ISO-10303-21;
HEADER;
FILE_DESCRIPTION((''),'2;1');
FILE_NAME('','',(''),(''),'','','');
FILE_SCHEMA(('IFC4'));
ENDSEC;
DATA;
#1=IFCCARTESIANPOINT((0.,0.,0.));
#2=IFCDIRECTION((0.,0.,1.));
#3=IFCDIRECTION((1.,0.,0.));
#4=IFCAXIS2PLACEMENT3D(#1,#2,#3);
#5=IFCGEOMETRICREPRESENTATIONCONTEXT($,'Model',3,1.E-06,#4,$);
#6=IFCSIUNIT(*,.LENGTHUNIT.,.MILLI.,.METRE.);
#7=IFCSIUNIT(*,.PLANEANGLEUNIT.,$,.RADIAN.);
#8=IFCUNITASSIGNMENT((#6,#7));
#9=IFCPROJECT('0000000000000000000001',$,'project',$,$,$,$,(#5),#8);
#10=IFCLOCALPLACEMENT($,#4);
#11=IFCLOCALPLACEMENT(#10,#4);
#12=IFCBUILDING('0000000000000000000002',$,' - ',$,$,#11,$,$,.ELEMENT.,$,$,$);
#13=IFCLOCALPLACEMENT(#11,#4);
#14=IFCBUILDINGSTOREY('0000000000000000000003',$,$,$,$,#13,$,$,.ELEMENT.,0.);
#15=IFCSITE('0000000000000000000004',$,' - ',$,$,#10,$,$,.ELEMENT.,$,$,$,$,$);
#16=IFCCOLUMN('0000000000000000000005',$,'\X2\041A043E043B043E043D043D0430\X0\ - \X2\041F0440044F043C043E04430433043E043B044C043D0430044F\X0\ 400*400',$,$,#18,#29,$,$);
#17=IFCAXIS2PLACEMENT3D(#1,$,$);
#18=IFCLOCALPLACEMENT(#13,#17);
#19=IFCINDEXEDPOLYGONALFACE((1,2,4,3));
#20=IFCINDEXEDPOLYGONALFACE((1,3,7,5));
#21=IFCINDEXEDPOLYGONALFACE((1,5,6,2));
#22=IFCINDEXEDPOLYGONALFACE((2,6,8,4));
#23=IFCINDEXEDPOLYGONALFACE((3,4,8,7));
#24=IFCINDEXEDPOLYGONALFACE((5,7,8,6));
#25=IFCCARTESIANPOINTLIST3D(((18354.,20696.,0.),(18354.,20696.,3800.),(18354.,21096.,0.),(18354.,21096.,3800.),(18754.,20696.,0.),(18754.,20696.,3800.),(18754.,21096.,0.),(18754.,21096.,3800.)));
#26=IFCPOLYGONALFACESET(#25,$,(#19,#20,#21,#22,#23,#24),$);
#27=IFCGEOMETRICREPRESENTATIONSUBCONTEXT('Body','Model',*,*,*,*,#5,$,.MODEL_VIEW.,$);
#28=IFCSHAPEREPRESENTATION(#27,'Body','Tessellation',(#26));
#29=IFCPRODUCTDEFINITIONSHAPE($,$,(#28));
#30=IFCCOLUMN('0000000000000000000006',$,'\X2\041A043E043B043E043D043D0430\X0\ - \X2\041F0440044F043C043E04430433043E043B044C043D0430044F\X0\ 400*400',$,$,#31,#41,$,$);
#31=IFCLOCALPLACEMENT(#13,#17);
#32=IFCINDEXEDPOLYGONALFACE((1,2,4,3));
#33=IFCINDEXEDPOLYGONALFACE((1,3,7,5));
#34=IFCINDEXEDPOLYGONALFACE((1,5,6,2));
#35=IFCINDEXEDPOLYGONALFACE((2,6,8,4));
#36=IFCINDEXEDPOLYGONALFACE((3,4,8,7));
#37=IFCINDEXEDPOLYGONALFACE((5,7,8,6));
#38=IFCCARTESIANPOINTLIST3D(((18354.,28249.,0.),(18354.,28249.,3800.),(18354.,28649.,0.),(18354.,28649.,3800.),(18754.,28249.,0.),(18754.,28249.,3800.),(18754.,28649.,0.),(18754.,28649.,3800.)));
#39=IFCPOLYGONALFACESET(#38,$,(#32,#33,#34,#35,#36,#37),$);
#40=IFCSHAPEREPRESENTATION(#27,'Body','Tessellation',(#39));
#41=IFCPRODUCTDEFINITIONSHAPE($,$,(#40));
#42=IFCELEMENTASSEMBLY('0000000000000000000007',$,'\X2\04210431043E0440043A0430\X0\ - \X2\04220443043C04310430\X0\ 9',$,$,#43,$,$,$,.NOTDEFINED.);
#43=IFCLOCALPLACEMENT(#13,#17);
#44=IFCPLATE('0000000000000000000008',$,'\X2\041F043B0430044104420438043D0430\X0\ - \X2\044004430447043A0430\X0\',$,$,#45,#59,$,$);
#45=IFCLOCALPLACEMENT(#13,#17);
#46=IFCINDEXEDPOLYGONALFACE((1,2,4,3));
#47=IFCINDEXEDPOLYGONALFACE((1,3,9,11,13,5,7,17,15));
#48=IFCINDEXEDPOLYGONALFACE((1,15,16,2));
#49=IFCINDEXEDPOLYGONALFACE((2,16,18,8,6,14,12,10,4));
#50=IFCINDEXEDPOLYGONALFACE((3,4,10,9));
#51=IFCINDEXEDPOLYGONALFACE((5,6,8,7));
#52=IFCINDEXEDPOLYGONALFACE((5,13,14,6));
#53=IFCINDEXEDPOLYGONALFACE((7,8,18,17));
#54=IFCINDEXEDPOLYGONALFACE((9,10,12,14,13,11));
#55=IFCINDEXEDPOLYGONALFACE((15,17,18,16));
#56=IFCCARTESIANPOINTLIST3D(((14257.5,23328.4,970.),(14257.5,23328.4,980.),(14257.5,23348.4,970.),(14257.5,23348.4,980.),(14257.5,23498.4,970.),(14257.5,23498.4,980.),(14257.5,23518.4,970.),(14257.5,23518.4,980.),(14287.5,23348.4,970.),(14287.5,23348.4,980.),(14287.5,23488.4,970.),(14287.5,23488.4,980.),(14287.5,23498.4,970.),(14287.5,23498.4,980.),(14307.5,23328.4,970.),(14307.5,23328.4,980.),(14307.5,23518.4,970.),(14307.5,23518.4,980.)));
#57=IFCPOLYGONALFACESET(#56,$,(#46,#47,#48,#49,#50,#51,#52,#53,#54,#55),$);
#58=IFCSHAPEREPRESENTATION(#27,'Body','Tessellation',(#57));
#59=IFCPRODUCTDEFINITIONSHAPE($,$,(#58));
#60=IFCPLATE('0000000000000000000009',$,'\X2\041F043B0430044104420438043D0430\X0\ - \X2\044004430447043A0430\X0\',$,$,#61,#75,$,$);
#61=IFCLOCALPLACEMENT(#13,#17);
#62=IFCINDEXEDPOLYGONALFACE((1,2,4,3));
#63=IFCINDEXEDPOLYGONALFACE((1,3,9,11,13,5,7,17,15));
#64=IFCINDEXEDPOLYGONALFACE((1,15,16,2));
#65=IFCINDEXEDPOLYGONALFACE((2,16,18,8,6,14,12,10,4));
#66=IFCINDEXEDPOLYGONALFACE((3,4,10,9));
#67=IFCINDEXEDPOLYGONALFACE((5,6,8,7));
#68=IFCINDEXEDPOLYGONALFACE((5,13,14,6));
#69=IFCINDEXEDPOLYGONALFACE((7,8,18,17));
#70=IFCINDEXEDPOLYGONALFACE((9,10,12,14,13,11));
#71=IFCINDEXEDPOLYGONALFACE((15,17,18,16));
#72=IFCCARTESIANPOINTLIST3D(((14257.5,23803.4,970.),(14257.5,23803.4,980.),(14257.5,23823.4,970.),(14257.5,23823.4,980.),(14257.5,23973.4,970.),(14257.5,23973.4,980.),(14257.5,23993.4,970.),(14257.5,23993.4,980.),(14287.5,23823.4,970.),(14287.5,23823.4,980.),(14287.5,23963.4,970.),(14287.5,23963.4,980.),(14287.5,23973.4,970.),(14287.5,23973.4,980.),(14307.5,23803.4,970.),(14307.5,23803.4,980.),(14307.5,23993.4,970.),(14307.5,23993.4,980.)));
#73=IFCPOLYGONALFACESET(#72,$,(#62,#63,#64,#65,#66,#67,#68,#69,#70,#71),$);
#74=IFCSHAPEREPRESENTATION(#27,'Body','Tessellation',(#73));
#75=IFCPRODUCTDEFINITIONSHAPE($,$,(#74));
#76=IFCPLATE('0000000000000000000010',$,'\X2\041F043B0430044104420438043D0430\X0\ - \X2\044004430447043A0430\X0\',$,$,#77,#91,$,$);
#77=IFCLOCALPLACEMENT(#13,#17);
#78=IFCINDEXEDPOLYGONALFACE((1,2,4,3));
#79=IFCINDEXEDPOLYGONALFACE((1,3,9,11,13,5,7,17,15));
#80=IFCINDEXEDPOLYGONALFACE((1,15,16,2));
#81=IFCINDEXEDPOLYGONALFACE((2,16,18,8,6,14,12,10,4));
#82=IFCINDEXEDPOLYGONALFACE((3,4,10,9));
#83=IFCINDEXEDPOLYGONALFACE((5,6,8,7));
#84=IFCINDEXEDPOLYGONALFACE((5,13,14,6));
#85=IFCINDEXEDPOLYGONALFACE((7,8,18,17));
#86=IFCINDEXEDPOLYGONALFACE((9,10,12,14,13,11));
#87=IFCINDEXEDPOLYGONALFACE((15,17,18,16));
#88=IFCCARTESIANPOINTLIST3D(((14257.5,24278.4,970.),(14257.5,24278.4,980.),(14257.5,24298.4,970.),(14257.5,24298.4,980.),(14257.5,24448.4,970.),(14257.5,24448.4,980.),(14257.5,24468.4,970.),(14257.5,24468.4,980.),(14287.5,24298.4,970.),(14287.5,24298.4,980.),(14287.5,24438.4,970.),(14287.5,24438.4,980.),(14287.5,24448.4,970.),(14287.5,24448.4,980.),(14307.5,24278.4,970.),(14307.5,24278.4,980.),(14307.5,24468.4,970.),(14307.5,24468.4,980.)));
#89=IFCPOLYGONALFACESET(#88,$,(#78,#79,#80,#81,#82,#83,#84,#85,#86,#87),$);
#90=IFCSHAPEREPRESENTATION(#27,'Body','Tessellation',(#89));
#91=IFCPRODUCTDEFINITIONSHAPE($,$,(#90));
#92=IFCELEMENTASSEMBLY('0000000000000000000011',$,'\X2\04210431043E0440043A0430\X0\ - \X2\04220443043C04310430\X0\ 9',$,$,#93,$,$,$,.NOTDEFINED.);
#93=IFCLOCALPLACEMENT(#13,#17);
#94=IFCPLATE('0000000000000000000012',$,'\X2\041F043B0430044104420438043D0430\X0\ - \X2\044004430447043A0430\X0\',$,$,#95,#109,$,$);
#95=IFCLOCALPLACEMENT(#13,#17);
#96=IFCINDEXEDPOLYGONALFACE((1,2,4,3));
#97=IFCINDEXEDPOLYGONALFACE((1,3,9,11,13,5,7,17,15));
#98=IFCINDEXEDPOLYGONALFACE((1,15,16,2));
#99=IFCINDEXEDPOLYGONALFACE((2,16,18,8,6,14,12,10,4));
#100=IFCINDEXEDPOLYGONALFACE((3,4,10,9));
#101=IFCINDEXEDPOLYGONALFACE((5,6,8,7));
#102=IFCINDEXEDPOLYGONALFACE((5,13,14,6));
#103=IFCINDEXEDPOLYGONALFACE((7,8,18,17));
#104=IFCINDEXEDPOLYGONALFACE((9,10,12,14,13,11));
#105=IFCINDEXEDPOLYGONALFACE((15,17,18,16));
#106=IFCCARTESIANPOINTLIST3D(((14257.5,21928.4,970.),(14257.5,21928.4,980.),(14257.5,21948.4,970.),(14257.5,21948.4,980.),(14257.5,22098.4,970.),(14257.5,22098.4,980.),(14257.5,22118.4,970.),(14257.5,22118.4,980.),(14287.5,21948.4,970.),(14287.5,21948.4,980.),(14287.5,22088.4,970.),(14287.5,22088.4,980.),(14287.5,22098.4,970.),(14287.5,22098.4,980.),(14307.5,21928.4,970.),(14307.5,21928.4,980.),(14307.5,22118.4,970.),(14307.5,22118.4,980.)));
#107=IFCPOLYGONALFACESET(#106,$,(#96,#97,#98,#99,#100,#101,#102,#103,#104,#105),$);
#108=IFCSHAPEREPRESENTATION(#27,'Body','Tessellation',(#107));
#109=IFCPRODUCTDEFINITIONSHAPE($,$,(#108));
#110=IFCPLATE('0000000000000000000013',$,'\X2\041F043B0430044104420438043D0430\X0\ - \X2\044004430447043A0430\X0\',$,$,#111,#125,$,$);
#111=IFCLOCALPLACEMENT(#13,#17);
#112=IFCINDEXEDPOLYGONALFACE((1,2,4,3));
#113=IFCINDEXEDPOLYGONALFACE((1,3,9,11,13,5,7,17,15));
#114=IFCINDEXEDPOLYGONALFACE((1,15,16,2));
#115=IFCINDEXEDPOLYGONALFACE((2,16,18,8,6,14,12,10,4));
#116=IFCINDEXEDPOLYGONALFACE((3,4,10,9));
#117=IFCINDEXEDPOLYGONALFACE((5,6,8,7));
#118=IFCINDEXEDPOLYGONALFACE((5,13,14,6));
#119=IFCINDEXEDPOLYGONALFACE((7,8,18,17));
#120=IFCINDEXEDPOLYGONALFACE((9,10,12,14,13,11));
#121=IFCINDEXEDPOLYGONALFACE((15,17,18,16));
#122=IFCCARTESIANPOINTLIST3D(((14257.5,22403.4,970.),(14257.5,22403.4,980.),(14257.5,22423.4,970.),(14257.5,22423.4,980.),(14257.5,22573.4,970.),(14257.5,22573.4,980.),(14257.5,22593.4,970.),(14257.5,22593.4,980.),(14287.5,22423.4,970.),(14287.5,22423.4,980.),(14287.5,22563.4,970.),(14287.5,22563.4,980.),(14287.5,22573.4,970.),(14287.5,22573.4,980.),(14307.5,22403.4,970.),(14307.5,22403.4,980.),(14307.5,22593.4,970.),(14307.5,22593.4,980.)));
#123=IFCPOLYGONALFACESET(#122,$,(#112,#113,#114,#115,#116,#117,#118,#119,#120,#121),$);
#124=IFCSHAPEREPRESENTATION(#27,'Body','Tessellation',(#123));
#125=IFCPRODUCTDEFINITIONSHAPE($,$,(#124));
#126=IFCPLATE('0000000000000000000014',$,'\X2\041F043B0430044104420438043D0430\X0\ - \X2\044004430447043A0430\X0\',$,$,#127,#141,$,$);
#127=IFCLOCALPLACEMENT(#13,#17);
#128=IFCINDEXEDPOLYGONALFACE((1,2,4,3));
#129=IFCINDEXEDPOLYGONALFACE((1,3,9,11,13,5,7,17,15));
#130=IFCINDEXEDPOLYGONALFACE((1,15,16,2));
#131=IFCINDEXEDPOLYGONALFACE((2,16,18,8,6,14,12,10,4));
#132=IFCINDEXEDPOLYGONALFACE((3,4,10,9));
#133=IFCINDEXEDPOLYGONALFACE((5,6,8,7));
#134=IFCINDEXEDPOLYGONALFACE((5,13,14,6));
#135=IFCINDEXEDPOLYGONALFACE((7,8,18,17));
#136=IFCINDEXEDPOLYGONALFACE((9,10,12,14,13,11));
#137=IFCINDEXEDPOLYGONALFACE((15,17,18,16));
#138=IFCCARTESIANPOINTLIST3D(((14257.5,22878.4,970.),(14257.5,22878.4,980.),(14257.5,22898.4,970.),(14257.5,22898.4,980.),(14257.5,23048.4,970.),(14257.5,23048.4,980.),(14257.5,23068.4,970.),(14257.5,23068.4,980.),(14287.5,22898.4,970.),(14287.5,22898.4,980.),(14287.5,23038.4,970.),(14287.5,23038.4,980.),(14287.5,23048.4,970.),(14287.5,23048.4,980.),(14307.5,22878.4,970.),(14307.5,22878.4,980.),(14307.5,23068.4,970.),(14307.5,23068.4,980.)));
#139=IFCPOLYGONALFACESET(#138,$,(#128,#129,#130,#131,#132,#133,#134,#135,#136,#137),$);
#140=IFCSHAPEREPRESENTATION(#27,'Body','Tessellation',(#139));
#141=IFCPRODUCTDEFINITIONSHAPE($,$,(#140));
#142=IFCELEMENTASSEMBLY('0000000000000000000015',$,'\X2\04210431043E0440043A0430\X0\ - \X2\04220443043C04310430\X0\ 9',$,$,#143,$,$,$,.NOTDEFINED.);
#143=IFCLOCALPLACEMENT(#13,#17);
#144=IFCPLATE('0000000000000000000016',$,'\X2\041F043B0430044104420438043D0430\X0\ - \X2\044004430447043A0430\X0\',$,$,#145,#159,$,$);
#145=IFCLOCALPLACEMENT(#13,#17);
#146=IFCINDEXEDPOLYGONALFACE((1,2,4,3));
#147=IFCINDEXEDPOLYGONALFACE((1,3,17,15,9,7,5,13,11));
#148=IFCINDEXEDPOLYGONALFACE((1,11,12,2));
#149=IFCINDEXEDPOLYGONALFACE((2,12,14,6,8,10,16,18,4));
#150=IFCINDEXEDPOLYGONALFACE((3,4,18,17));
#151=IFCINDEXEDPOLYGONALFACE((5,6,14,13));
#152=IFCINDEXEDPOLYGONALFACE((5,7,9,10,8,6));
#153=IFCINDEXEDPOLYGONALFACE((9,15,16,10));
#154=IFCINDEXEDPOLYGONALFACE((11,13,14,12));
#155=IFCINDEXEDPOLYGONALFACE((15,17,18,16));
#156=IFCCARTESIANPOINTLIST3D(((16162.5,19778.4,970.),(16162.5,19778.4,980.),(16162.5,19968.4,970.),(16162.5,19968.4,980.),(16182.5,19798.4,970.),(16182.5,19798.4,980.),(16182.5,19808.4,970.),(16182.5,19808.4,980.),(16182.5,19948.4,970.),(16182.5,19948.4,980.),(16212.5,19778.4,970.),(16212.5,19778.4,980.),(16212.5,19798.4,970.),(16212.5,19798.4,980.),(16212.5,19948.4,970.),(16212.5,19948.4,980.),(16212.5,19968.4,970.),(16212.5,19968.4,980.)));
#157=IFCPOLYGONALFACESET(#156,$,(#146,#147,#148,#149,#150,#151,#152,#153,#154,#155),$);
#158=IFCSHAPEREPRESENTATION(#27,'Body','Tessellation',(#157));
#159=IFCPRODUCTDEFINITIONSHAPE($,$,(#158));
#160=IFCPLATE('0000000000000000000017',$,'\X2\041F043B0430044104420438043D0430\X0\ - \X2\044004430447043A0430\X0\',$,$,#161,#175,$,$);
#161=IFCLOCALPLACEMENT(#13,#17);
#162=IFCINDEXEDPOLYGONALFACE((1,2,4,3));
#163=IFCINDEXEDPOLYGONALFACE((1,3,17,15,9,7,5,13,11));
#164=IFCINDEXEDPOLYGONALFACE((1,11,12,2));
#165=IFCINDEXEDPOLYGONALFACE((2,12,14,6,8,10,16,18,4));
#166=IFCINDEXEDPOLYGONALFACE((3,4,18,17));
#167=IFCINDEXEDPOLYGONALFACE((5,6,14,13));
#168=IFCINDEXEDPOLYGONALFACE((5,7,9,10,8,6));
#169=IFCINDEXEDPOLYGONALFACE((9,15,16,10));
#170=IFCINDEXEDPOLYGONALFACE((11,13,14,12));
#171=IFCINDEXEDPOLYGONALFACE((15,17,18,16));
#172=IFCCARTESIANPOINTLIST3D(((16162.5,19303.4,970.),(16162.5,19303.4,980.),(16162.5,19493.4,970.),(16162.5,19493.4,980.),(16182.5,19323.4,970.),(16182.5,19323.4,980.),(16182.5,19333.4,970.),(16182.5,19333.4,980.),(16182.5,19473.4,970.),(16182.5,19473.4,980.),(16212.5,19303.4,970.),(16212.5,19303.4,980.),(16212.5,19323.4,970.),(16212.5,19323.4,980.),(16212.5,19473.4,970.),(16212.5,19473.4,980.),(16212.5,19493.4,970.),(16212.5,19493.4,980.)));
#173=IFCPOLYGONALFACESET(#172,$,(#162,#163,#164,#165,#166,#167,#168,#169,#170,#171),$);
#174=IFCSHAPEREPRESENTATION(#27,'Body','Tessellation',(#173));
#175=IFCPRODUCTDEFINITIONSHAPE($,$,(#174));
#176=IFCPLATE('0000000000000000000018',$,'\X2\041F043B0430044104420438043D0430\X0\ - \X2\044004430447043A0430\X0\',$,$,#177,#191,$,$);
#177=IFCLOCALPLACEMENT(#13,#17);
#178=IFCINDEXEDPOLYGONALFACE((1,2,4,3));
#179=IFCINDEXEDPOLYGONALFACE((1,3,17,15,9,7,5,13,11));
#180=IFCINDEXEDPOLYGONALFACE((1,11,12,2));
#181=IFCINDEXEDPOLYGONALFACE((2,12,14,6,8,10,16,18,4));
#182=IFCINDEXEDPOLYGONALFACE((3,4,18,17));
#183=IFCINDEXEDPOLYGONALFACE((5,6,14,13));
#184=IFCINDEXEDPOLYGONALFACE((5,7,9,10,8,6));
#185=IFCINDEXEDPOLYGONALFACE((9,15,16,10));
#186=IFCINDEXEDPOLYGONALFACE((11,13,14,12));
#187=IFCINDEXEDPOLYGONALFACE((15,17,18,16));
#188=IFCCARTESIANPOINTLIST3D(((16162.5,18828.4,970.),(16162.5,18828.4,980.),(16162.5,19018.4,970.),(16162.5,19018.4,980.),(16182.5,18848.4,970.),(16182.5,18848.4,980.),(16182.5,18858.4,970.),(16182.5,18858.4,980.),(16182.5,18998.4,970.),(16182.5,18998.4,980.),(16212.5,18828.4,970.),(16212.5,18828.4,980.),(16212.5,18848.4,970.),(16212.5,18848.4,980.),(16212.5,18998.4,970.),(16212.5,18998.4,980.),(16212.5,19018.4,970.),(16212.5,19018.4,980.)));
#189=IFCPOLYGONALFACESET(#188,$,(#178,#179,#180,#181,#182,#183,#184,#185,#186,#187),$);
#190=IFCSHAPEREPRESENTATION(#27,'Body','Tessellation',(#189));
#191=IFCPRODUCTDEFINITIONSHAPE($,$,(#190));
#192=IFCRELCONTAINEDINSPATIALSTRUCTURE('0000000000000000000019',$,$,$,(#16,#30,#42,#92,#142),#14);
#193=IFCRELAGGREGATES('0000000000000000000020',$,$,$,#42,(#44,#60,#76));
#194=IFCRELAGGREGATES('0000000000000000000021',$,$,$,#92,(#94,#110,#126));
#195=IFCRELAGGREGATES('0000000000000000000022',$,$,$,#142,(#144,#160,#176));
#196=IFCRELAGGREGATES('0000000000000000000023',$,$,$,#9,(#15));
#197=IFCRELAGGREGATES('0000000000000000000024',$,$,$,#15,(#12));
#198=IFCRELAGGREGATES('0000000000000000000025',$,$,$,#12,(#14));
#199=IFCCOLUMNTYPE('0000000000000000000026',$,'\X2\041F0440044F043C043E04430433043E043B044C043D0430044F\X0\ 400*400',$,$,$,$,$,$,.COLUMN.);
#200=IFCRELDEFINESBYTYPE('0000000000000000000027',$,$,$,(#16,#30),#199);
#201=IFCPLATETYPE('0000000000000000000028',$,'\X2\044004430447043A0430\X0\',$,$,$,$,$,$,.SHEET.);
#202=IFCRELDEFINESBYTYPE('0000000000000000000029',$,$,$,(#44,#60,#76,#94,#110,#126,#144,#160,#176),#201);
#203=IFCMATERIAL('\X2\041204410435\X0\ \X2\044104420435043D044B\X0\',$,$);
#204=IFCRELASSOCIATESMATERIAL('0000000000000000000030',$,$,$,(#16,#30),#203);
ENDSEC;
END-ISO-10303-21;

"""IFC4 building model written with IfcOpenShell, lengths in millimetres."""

from ifc_helpers import new_model, si_unit, frame, origin_with_axes, place, context, subcontext, project, spatial, line, indexed_curve, outline, extrude, source, transform, mapped, material, type_object, element, aggregate, save


model = new_model("IFC4")

# Units and contexts
model_context = context("Model", 3, precision=1e-06, world=origin_with_axes())
body_context = subcontext(model_context, "Body", "Model", "MODEL_VIEW")
ifc_project = project(units=[si_unit("LENGTHUNIT", "METRE", prefix="MILLI"), si_unit("PLANEANGLEUNIT", "RADIAN")], contexts=[model_context])

# Site, building, storey
site_placement = place(None, origin_with_axes())
site = spatial("IfcSite", under=ifc_project, at=site_placement, Name=" - ", CompositionType="ELEMENT")
building_placement = place(site_placement, origin_with_axes())
building = spatial("IfcBuilding", under=site, at=building_placement, Name=" - ", CompositionType="ELEMENT")
storey_placement = place(building_placement, origin_with_axes())
storey = spatial("IfcBuildingStorey", under=building, at=storey_placement, CompositionType="ELEMENT", Elevation=0.0)

# Columns
ifc_material = material(Name="Все стены")
column_type = type_object("IfcColumnType", Name="Прямоугольная 400*400", PredefinedType="COLUMN")
shared_shape_1 = source(origin_with_axes(), body_context, "Body", "SweptSolid", [
    extrude(outline(indexed_curve([(-200.0, -200.0), (200.0, -200.0), (200.0, 200.0), (-200.0, 200.0)], segments=[line(1, 2), line(2, 3), line(3, 4), line(4, 1)])), origin_with_axes(), (0.0, 0.0, 1.0), 3800.0),
])
for number, where, z_axis, x_axis, name in (
    (1, (18554.0, 20896.0, 0.0), (0.0, 0.0, 1.0), (1.0, 0.0, 0.0), "Колонна - Прямоугольная 400*400"),
    (2, (18554.0, 28449.0, 0.0), (0.0, 0.0, 1.0), (1.0, 0.0, 0.0), "Колонна - Прямоугольная 400*400"),
):
    element("IfcColumn", number, at=place(storey_placement, frame(where, z_axis=z_axis, x_axis=x_axis)), inside=storey, type_object=column_type, material=ifc_material, Name=name, context=body_context, shape_type="MappedRepresentation", body=[
        mapped(shared_shape_1, transform((0.0, 0.0, 0.0), x_axis=(1.0, 0.0, 0.0), y_axis=(0.0, 1.0, 0.0), z_axis=(0.0, 0.0, 1.0), scale=1.0)),
    ])

# Element assemblies, plates
assembly_1_placement = place(storey_placement, frame((14042.5, 23898.4, 0.0), z_axis=(0.0, 0.0, 1.0), x_axis=(0.0, 1.0, 0.0)))
assembly_1 = element("IfcElementAssembly", 3, at=assembly_1_placement, inside=storey, Name="Сборка - Тумба 9", PredefinedType="NOTDEFINED")
plate_type = type_object("IfcPlateType", Name="ручка", PredefinedType="SHEET")
shared_shape_2 = source(origin_with_axes(), body_context, "Body", "SweptSolid", [
    extrude(outline(indexed_curve([(-95.0, -25.0), (-75.0, -25.0), (-75.0, 5.0), (-65.0, 5.0), (75.0, 5.0), (75.0, -25.0), (95.0, -25.0), (95.0, 25.0), (-95.0, 25.0)], segments=[line(1, 2), line(2, 3), line(3, 4), line(4, 5), line(5, 6), line(6, 7), line(7, 8), line(8, 9), line(9, 1)])), origin_with_axes(), (0.0, 0.0, 1.0), 10.0),
])
plate_1_placement = place(assembly_1_placement, frame((-475.0, -240.0, 970.0), z_axis=(0.0, 0.0, 1.0), x_axis=(-1.0, 0.0, 0.0)))
plate_1 = element("IfcPlate", 4, at=plate_1_placement, type_object=plate_type, Name="Пластина - ручка", context=body_context, shape_type="MappedRepresentation", body=[
    mapped(shared_shape_2, transform((0.0, 0.0, 0.0), x_axis=(1.0, 0.0, 0.0), y_axis=(0.0, 1.0, 0.0), z_axis=(0.0, 0.0, 1.0), scale=1.0)),
])
plate_2_placement = place(assembly_1_placement, frame((0.0, -240.0, 970.0), z_axis=(0.0, 0.0, 1.0), x_axis=(-1.0, 0.0, 0.0)))
plate_2 = element("IfcPlate", 5, at=plate_2_placement, type_object=plate_type, Name="Пластина - ручка", context=body_context, shape_type="MappedRepresentation", body=[
    mapped(shared_shape_2, transform((0.0, 0.0, 0.0), x_axis=(1.0, 0.0, 0.0), y_axis=(0.0, 1.0, 0.0), z_axis=(0.0, 0.0, 1.0), scale=1.0)),
])
plate_3_placement = place(assembly_1_placement, frame((475.0, -240.0, 970.0), z_axis=(0.0, 0.0, 1.0), x_axis=(-1.0, 0.0, 0.0)))
plate_3 = element("IfcPlate", 6, at=plate_3_placement, type_object=plate_type, Name="Пластина - ручка", context=body_context, shape_type="MappedRepresentation", body=[
    mapped(shared_shape_2, transform((0.0, 0.0, 0.0), x_axis=(1.0, 0.0, 0.0), y_axis=(0.0, 1.0, 0.0), z_axis=(0.0, 0.0, 1.0), scale=1.0)),
])
aggregate(assembly_1, [plate_1, plate_2, plate_3])
assembly_2_placement = place(storey_placement, frame((14042.5, 22498.4, 0.0), z_axis=(0.0, 0.0, 1.0), x_axis=(0.0, 1.0, 0.0)))
assembly_2 = element("IfcElementAssembly", 7, at=assembly_2_placement, inside=storey, Name="Сборка - Тумба 9", PredefinedType="NOTDEFINED")
plate_4_placement = place(assembly_2_placement, frame((-475.0, -240.0, 970.0), z_axis=(0.0, 0.0, 1.0), x_axis=(-1.0, 0.0, 0.0)))
plate_4 = element("IfcPlate", 8, at=plate_4_placement, type_object=plate_type, Name="Пластина - ручка", context=body_context, shape_type="MappedRepresentation", body=[
    mapped(shared_shape_2, transform((0.0, 0.0, 0.0), x_axis=(1.0, 0.0, 0.0), y_axis=(0.0, 1.0, 0.0), z_axis=(0.0, 0.0, 1.0), scale=1.0)),
])
plate_5_placement = place(assembly_2_placement, frame((0.0, -240.0, 970.0), z_axis=(0.0, 0.0, 1.0), x_axis=(-1.0, 0.0, 0.0)))
plate_5 = element("IfcPlate", 9, at=plate_5_placement, type_object=plate_type, Name="Пластина - ручка", context=body_context, shape_type="MappedRepresentation", body=[
    mapped(shared_shape_2, transform((0.0, 0.0, 0.0), x_axis=(1.0, 0.0, 0.0), y_axis=(0.0, 1.0, 0.0), z_axis=(0.0, 0.0, 1.0), scale=1.0)),
])
plate_6_placement = place(assembly_2_placement, frame((475.0, -240.0, 970.0), z_axis=(0.0, 0.0, 1.0), x_axis=(-1.0, 0.0, 0.0)))
plate_6 = element("IfcPlate", 10, at=plate_6_placement, type_object=plate_type, Name="Пластина - ручка", context=body_context, shape_type="MappedRepresentation", body=[
    mapped(shared_shape_2, transform((0.0, 0.0, 0.0), x_axis=(1.0, 0.0, 0.0), y_axis=(0.0, 1.0, 0.0), z_axis=(0.0, 0.0, 1.0), scale=1.0)),
])
aggregate(assembly_2, [plate_4, plate_5, plate_6])
assembly_3_placement = place(storey_placement, frame((16427.5, 19398.4, 0.0), z_axis=(0.0, 0.0, 1.0), x_axis=(0.0, -1.0, 0.0)))
assembly_3 = element("IfcElementAssembly", 11, at=assembly_3_placement, inside=storey, Name="Сборка - Тумба 9", PredefinedType="NOTDEFINED")
plate_7_placement = place(assembly_3_placement, frame((-475.0, -240.0, 970.0), z_axis=(0.0, 0.0, 1.0), x_axis=(-1.0, 0.0, 0.0)))
plate_7 = element("IfcPlate", 12, at=plate_7_placement, type_object=plate_type, Name="Пластина - ручка", context=body_context, shape_type="MappedRepresentation", body=[
    mapped(shared_shape_2, transform((0.0, 0.0, 0.0), x_axis=(1.0, 0.0, 0.0), y_axis=(0.0, 1.0, 0.0), z_axis=(0.0, 0.0, 1.0), scale=1.0)),
])
plate_8_placement = place(assembly_3_placement, frame((0.0, -240.0, 970.0), z_axis=(0.0, 0.0, 1.0), x_axis=(-1.0, 0.0, 0.0)))
plate_8 = element("IfcPlate", 13, at=plate_8_placement, type_object=plate_type, Name="Пластина - ручка", context=body_context, shape_type="MappedRepresentation", body=[
    mapped(shared_shape_2, transform((0.0, 0.0, 0.0), x_axis=(1.0, 0.0, 0.0), y_axis=(0.0, 1.0, 0.0), z_axis=(0.0, 0.0, 1.0), scale=1.0)),
])
plate_9_placement = place(assembly_3_placement, frame((475.0, -240.0, 970.0), z_axis=(0.0, 0.0, 1.0), x_axis=(-1.0, 0.0, 0.0)))
plate_9 = element("IfcPlate", 14, at=plate_9_placement, type_object=plate_type, Name="Пластина - ручка", context=body_context, shape_type="MappedRepresentation", body=[
    mapped(shared_shape_2, transform((0.0, 0.0, 0.0), x_axis=(1.0, 0.0, 0.0), y_axis=(0.0, 1.0, 0.0), z_axis=(0.0, 0.0, 1.0), scale=1.0)),
])
aggregate(assembly_3, [plate_7, plate_8, plate_9])

save(model, "model.ifc")
